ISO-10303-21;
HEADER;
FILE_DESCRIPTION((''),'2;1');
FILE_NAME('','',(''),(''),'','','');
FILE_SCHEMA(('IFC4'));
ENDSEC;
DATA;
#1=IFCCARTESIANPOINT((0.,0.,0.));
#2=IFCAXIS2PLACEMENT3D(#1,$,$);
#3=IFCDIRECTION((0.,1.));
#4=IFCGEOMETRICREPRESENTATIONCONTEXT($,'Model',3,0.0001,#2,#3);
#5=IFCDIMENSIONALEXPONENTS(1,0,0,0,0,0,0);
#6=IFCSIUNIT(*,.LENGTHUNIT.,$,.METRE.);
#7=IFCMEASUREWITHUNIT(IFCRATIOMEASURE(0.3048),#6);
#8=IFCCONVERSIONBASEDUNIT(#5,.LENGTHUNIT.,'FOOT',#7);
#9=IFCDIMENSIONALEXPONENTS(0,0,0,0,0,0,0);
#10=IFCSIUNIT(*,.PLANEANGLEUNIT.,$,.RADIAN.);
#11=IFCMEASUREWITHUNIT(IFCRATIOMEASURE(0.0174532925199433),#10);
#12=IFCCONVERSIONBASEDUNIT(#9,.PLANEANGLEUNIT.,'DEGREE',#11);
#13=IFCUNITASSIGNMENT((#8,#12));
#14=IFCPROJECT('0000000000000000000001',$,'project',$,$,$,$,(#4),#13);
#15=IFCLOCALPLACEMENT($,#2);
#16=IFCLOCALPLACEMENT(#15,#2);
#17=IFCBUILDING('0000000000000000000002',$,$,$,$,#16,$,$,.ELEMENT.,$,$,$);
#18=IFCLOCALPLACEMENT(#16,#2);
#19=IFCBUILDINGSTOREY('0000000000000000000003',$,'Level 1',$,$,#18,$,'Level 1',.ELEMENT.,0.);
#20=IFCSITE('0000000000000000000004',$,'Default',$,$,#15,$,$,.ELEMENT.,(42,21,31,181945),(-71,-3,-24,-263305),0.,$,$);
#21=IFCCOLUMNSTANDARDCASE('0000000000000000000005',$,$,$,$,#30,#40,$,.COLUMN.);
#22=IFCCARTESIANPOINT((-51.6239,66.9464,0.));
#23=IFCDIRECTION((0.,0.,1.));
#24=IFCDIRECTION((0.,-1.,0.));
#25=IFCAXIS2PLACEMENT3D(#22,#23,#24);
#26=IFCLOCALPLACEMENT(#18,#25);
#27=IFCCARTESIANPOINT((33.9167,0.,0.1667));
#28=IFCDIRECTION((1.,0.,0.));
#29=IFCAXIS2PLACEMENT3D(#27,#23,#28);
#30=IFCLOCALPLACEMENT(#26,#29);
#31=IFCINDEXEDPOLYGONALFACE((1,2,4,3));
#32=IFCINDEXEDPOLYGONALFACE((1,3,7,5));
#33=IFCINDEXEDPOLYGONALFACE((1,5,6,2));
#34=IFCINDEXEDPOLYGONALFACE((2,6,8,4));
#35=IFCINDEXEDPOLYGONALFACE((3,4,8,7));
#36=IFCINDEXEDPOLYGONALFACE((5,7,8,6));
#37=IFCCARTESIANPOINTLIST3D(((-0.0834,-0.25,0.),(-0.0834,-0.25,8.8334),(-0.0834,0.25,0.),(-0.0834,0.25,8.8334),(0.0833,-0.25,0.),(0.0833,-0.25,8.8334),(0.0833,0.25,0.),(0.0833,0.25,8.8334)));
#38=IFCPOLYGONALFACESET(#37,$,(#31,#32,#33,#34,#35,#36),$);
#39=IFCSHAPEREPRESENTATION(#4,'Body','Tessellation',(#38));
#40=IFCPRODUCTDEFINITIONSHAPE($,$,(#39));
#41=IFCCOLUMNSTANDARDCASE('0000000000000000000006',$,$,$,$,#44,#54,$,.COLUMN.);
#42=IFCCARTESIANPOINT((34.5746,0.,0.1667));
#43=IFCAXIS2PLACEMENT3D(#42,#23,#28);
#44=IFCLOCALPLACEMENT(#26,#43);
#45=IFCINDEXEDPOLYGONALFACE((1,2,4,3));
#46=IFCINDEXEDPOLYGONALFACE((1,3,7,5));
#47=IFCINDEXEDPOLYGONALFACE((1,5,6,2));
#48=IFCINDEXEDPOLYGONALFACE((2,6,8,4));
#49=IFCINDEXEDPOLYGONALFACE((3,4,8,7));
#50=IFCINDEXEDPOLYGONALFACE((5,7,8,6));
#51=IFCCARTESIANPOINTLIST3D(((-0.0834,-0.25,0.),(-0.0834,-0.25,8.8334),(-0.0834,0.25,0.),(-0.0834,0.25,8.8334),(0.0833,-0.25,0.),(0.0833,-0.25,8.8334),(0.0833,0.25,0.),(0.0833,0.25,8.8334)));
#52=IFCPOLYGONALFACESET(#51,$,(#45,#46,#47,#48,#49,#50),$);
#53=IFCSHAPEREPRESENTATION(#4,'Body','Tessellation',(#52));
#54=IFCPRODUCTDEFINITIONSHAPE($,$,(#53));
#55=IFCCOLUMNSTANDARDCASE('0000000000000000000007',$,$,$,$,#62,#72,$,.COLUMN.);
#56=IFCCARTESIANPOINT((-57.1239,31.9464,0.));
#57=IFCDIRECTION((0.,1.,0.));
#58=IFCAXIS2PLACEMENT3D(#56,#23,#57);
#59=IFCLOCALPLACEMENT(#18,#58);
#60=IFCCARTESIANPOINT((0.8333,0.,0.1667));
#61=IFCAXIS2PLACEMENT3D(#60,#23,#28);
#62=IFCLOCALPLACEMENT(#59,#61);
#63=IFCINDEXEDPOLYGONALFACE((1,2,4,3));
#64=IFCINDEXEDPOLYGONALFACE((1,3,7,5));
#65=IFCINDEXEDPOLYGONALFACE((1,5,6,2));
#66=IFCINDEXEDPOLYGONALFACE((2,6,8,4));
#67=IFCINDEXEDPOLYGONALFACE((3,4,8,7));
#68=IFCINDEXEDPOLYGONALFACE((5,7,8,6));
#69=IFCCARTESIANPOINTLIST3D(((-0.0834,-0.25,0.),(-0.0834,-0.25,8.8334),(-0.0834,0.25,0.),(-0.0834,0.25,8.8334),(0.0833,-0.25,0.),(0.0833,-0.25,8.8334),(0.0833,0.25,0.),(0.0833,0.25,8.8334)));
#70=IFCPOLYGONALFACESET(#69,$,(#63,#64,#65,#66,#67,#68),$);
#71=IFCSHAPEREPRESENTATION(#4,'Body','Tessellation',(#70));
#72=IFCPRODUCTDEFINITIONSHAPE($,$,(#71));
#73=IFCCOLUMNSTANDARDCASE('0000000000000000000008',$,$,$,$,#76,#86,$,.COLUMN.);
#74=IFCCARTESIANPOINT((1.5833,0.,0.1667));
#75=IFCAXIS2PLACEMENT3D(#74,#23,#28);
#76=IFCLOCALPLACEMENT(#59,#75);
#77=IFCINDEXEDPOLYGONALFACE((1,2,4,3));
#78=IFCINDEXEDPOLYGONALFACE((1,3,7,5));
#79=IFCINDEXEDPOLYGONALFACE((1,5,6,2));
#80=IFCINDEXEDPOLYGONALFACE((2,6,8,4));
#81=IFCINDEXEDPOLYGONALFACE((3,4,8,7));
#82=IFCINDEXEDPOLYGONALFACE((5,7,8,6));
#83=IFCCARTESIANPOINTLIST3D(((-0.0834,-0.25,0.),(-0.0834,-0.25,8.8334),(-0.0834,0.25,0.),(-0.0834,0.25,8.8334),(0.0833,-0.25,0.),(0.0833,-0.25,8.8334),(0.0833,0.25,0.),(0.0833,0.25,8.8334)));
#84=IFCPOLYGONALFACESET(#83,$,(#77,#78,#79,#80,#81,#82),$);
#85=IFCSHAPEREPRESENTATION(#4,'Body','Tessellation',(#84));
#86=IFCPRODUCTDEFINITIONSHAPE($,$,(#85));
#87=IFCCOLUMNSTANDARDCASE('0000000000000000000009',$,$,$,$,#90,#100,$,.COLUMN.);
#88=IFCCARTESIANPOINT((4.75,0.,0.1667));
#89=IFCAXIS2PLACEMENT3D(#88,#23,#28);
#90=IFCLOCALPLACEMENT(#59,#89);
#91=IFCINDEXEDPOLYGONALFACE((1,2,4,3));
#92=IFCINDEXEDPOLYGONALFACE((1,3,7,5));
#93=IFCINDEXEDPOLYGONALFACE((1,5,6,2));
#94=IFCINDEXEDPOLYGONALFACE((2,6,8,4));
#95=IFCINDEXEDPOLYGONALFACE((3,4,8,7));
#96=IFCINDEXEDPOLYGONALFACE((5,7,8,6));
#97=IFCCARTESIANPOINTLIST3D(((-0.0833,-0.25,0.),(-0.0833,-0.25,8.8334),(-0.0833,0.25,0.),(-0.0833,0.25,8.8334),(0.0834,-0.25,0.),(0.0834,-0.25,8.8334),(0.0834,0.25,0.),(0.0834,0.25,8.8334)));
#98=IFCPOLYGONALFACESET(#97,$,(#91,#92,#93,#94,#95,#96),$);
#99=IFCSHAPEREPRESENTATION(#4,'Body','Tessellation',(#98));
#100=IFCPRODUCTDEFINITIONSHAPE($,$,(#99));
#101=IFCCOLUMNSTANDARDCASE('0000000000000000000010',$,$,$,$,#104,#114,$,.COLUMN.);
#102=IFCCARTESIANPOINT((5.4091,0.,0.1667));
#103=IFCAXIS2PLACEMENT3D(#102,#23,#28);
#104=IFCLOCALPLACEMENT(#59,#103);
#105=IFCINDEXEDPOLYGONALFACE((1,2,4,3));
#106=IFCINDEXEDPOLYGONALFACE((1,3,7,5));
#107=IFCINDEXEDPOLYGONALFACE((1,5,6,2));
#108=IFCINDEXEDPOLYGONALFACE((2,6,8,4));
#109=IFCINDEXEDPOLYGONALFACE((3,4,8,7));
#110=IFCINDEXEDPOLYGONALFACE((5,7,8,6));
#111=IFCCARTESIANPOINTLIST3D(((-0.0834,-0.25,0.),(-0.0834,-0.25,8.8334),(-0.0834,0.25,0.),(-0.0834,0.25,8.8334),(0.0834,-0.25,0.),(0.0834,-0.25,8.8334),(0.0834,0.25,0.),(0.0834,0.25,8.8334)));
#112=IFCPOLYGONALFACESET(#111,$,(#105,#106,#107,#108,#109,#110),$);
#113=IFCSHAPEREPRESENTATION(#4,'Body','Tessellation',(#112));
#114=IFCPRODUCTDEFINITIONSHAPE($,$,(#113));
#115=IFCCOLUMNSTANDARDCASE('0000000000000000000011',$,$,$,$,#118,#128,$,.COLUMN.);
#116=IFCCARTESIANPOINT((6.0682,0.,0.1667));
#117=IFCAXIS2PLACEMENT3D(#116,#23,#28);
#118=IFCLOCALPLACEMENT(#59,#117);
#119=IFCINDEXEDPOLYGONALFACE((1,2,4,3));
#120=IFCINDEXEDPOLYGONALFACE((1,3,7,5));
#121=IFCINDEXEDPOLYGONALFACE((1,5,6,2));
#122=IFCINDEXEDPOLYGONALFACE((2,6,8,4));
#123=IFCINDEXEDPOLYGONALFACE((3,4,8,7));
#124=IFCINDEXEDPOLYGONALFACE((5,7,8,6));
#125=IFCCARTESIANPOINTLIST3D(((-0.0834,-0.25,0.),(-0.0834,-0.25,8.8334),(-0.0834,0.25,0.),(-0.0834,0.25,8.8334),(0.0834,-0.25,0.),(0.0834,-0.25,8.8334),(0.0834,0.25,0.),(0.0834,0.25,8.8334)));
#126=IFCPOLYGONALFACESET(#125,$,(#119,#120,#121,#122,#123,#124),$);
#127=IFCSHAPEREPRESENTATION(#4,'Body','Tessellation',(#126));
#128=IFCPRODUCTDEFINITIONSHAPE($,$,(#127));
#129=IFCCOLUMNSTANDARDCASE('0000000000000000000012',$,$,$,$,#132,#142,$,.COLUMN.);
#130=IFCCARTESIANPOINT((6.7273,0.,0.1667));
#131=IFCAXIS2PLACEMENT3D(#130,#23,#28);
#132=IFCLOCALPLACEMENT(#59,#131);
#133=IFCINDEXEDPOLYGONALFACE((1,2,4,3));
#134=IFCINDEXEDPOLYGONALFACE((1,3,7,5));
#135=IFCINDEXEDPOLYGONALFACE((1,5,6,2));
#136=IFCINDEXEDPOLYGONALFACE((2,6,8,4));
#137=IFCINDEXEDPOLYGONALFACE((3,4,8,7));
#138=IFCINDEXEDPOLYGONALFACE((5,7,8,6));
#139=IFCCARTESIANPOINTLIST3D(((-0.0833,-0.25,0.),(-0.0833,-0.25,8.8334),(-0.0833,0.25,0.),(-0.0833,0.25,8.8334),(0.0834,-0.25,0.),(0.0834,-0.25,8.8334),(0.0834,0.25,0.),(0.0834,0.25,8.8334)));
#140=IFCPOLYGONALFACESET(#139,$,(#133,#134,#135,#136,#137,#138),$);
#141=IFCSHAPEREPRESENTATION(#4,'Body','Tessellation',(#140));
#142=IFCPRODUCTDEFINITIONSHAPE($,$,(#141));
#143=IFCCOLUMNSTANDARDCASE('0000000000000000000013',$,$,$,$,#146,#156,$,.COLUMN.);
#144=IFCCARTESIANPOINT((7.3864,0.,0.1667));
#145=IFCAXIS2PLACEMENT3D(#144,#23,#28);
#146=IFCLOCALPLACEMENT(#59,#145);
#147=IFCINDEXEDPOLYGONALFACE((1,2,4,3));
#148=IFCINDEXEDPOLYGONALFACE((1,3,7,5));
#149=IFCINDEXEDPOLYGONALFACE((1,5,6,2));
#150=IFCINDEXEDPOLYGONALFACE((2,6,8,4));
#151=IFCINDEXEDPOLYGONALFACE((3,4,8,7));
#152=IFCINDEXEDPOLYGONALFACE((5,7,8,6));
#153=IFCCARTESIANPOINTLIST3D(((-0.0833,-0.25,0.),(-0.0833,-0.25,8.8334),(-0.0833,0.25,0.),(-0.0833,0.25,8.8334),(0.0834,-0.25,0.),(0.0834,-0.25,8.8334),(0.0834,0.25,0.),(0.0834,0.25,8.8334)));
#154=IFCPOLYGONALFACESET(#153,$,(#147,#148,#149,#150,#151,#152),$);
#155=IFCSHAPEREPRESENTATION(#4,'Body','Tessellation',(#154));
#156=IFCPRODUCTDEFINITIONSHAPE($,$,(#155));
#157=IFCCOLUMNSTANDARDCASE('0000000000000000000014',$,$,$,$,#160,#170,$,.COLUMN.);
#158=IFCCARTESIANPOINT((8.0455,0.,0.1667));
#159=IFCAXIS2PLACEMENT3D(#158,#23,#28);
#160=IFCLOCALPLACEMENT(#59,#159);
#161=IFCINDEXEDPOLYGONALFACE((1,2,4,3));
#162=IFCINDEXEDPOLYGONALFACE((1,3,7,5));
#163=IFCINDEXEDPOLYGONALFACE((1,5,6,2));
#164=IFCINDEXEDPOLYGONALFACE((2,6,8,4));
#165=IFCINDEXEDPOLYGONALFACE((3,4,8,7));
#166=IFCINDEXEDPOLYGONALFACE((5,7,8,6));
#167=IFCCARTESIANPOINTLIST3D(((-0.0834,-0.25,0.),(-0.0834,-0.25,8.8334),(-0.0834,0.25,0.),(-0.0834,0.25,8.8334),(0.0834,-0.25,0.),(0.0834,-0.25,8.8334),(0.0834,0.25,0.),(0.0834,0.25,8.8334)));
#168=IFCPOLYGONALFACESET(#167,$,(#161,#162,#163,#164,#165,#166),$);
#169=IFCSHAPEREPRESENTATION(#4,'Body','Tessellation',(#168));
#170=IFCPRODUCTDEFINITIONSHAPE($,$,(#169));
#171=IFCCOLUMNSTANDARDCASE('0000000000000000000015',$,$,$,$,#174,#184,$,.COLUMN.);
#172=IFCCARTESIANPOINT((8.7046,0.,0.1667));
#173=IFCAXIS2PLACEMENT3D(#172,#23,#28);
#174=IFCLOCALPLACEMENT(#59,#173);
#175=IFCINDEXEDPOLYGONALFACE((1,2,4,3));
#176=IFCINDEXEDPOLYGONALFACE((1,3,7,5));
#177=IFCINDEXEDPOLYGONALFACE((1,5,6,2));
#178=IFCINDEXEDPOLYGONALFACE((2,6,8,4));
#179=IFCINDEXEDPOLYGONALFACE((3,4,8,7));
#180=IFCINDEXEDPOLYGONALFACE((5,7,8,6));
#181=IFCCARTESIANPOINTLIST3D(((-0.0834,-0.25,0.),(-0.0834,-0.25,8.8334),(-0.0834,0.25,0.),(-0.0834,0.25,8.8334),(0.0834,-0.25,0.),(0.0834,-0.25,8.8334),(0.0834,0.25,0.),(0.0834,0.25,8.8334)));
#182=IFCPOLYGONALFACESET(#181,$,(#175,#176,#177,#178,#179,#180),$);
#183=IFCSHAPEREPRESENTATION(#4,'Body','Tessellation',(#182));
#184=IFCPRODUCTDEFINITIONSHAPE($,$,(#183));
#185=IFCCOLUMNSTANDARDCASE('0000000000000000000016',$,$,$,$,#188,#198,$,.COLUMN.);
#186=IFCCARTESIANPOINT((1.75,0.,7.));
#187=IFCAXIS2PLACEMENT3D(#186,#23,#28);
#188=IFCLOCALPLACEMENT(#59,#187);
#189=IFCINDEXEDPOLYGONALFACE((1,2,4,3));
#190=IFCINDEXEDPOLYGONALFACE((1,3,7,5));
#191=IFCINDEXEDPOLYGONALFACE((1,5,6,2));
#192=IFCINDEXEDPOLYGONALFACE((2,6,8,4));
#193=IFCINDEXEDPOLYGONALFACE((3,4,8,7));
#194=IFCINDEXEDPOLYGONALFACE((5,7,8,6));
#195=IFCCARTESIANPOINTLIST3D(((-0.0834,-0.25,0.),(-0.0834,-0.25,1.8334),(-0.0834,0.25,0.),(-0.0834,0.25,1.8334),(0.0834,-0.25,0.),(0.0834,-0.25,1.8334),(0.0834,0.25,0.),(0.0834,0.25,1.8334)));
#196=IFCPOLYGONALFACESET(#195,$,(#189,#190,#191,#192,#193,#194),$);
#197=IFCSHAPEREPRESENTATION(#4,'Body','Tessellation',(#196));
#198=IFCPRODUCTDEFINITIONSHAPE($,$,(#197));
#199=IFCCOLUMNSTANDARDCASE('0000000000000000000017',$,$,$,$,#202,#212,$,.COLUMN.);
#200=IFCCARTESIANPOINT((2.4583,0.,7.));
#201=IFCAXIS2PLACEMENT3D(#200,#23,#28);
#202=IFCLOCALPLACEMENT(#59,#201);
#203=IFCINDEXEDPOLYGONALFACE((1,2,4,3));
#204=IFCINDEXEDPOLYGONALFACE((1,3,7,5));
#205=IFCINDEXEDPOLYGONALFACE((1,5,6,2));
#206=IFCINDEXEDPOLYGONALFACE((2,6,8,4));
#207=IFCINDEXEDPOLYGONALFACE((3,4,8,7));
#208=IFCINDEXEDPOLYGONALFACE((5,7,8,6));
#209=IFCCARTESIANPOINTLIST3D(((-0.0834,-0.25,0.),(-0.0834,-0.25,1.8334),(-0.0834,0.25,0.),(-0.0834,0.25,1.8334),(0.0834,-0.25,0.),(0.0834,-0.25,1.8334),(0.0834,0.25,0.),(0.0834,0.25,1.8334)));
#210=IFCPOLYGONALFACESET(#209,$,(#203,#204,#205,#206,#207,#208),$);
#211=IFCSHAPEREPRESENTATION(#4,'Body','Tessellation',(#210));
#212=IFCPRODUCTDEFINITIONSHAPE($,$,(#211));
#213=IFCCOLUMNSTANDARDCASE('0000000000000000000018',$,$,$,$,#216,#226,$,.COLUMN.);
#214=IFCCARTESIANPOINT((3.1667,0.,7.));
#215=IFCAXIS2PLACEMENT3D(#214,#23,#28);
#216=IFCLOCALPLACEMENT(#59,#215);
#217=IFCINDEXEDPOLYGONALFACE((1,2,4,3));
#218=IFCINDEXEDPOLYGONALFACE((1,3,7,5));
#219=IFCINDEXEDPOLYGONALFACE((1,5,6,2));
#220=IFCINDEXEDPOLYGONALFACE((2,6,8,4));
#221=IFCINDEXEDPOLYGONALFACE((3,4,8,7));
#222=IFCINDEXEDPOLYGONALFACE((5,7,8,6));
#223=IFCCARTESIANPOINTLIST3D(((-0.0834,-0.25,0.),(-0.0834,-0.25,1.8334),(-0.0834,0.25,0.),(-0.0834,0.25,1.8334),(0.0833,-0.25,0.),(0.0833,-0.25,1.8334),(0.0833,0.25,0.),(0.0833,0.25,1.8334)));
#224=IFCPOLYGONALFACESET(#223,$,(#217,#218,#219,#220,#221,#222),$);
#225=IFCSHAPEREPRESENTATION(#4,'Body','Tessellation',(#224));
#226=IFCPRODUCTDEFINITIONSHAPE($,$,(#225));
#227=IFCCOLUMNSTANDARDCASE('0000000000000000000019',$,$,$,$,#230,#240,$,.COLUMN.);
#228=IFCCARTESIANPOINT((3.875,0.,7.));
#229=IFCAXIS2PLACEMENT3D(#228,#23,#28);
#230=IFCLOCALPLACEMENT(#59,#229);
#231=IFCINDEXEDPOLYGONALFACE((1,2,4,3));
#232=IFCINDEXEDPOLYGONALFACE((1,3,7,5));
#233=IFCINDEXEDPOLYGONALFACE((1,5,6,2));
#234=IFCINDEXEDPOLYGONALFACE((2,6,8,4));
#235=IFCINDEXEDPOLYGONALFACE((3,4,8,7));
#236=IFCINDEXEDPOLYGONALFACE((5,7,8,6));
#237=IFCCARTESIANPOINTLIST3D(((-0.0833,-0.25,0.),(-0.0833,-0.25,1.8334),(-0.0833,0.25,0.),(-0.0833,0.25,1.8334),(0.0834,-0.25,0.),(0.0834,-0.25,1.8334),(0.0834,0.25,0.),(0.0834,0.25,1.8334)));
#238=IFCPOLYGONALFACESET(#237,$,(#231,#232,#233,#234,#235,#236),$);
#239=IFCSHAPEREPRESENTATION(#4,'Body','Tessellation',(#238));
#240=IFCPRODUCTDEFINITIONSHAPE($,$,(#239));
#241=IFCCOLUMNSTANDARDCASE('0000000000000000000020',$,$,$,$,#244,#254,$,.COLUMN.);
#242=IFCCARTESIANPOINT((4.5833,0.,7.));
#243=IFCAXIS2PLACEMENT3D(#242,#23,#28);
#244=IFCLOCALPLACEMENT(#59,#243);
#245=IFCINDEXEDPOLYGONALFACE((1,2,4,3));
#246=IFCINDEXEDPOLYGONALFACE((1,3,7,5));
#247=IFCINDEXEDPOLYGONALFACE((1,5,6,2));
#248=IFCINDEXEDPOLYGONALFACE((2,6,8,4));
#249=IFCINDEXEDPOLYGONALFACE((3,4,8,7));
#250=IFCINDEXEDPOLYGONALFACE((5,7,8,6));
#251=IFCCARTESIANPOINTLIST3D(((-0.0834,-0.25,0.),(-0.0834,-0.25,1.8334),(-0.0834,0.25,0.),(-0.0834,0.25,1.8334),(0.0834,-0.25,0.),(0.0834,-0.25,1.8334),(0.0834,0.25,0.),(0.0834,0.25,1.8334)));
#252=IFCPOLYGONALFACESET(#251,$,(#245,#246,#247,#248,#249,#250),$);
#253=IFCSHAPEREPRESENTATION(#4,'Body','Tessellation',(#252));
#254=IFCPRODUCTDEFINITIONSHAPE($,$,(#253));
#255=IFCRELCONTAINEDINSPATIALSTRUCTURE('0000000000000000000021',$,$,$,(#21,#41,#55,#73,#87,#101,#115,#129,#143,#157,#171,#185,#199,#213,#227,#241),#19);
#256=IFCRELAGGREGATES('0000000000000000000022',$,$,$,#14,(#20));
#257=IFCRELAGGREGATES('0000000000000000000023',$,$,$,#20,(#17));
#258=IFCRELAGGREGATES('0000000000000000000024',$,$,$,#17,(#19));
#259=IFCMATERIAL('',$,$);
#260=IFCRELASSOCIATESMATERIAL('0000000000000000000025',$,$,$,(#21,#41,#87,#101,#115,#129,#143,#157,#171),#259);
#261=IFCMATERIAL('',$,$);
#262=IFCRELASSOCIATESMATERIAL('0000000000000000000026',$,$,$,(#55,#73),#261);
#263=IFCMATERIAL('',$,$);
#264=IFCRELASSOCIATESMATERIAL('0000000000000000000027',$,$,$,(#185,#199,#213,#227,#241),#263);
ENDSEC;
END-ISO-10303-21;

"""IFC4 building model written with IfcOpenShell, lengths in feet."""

from ifc_helpers import new_model, entity, si_unit, converted_unit, direction, frame, origin, place, context, project, spatial, rectangle, extrude, material, element, save


model = new_model("IFC4")

# Units and contexts
model_context = context("Model", 3, precision=0.0001, world=origin(), true_north=direction((0.0, 1.0)))
ifc_project = project(units=[converted_unit("LENGTHUNIT", "FOOT", entity("IfcRatioMeasure", 0.3048), si_unit("LENGTHUNIT", "METRE"), dimensions=[1, 0, 0, 0, 0, 0, 0]), converted_unit("PLANEANGLEUNIT", "DEGREE", entity("IfcRatioMeasure", 0.0174532925199433), si_unit("PLANEANGLEUNIT", "RADIAN"), dimensions=[0, 0, 0, 0, 0, 0, 0])], contexts=[model_context])

# Site, building, storey
site_placement = place(None, origin())
site = spatial("IfcSite", under=ifc_project, at=site_placement, Name="Default", CompositionType="ELEMENT", RefLatitude=(42, 21, 31, 181945), RefLongitude=(-71, -3, -24, -263305), RefElevation=0.0)
building_placement = place(site_placement, origin())
building = spatial("IfcBuilding", under=site, at=building_placement, CompositionType="ELEMENT")
storey_placement = place(building_placement, origin())
storey = spatial("IfcBuildingStorey", under=building, at=storey_placement, Name="Level 1", LongName="Level 1", CompositionType="ELEMENT", Elevation=0.0)

# Columns
ifc_material_1 = material(Name="")
placement_1 = place(storey_placement, frame((-51.6239, 66.9464, 0.0), z_axis=(0.0, 0.0, 1.0), x_axis=(0.0, -1.0, 0.0)))
for number, where, z_axis, x_axis in (
    (1, (33.9167, 0.0, 0.1667), (0.0, 0.0, 1.0), (1.0, 0.0, 0.0)),
    (2, (34.5746, 0.0, 0.1667), (0.0, 0.0, 1.0), (1.0, 0.0, 0.0)),
):
    element("IfcColumnStandardCase", number, at=place(placement_1, frame(where, z_axis=z_axis, x_axis=x_axis)), inside=storey, material=ifc_material_1, PredefinedType="COLUMN", context=model_context, shape_type="SweptSolid", body=[
        extrude(rectangle(XDim=0.1667, YDim=0.5), origin(), (0.0, 0.0, 1.0), 8.8334),
    ])
ifc_material_2 = material(Name="")
placement_2 = place(storey_placement, frame((-57.1239, 31.9464, 0.0), z_axis=(0.0, 0.0, 1.0), x_axis=(0.0, 1.0, 0.0)))
for number, where, z_axis, x_axis in (
    (3, (0.8333, 0.0, 0.1667), (0.0, 0.0, 1.0), (1.0, 0.0, 0.0)),
    (4, (1.5833, 0.0, 0.1667), (0.0, 0.0, 1.0), (1.0, 0.0, 0.0)),
):
    element("IfcColumnStandardCase", number, at=place(placement_2, frame(where, z_axis=z_axis, x_axis=x_axis)), inside=storey, material=ifc_material_2, PredefinedType="COLUMN", context=model_context, shape_type="SweptSolid", body=[
        extrude(rectangle(XDim=0.1667, YDim=0.5), origin(), (0.0, 0.0, 1.0), 8.8334),
    ])
for number, where, z_axis, x_axis in (
    (5, (4.75, 0.0, 0.1667), (0.0, 0.0, 1.0), (1.0, 0.0, 0.0)),
    (6, (5.4091, 0.0, 0.1667), (0.0, 0.0, 1.0), (1.0, 0.0, 0.0)),
    (7, (6.0682, 0.0, 0.1667), (0.0, 0.0, 1.0), (1.0, 0.0, 0.0)),
    (8, (6.7273, 0.0, 0.1667), (0.0, 0.0, 1.0), (1.0, 0.0, 0.0)),
    (9, (7.3864, 0.0, 0.1667), (0.0, 0.0, 1.0), (1.0, 0.0, 0.0)),
    (10, (8.0455, 0.0, 0.1667), (0.0, 0.0, 1.0), (1.0, 0.0, 0.0)),
    (11, (8.7046, 0.0, 0.1667), (0.0, 0.0, 1.0), (1.0, 0.0, 0.0)),
):
    element("IfcColumnStandardCase", number, at=place(placement_2, frame(where, z_axis=z_axis, x_axis=x_axis)), inside=storey, material=ifc_material_1, PredefinedType="COLUMN", context=model_context, shape_type="SweptSolid", body=[
        extrude(rectangle(XDim=0.1667, YDim=0.5), origin(), (0.0, 0.0, 1.0), 8.8334),
    ])
ifc_material_3 = material(Name="")
for number, where, z_axis, x_axis in (
    (12, (1.75, 0.0, 7.0), (0.0, 0.0, 1.0), (1.0, 0.0, 0.0)),
    (13, (2.4583, 0.0, 7.0), (0.0, 0.0, 1.0), (1.0, 0.0, 0.0)),
    (14, (3.1667, 0.0, 7.0), (0.0, 0.0, 1.0), (1.0, 0.0, 0.0)),
    (15, (3.875, 0.0, 7.0), (0.0, 0.0, 1.0), (1.0, 0.0, 0.0)),
    (16, (4.5833, 0.0, 7.0), (0.0, 0.0, 1.0), (1.0, 0.0, 0.0)),
):
    element("IfcColumnStandardCase", number, at=place(placement_2, frame(where, z_axis=z_axis, x_axis=x_axis)), inside=storey, material=ifc_material_3, PredefinedType="COLUMN", context=model_context, shape_type="SweptSolid", body=[
        extrude(rectangle(XDim=0.1667, YDim=0.5), origin(), (0.0, 0.0, 1.0), 1.8334),
    ])

save(model, "model.ifc")
